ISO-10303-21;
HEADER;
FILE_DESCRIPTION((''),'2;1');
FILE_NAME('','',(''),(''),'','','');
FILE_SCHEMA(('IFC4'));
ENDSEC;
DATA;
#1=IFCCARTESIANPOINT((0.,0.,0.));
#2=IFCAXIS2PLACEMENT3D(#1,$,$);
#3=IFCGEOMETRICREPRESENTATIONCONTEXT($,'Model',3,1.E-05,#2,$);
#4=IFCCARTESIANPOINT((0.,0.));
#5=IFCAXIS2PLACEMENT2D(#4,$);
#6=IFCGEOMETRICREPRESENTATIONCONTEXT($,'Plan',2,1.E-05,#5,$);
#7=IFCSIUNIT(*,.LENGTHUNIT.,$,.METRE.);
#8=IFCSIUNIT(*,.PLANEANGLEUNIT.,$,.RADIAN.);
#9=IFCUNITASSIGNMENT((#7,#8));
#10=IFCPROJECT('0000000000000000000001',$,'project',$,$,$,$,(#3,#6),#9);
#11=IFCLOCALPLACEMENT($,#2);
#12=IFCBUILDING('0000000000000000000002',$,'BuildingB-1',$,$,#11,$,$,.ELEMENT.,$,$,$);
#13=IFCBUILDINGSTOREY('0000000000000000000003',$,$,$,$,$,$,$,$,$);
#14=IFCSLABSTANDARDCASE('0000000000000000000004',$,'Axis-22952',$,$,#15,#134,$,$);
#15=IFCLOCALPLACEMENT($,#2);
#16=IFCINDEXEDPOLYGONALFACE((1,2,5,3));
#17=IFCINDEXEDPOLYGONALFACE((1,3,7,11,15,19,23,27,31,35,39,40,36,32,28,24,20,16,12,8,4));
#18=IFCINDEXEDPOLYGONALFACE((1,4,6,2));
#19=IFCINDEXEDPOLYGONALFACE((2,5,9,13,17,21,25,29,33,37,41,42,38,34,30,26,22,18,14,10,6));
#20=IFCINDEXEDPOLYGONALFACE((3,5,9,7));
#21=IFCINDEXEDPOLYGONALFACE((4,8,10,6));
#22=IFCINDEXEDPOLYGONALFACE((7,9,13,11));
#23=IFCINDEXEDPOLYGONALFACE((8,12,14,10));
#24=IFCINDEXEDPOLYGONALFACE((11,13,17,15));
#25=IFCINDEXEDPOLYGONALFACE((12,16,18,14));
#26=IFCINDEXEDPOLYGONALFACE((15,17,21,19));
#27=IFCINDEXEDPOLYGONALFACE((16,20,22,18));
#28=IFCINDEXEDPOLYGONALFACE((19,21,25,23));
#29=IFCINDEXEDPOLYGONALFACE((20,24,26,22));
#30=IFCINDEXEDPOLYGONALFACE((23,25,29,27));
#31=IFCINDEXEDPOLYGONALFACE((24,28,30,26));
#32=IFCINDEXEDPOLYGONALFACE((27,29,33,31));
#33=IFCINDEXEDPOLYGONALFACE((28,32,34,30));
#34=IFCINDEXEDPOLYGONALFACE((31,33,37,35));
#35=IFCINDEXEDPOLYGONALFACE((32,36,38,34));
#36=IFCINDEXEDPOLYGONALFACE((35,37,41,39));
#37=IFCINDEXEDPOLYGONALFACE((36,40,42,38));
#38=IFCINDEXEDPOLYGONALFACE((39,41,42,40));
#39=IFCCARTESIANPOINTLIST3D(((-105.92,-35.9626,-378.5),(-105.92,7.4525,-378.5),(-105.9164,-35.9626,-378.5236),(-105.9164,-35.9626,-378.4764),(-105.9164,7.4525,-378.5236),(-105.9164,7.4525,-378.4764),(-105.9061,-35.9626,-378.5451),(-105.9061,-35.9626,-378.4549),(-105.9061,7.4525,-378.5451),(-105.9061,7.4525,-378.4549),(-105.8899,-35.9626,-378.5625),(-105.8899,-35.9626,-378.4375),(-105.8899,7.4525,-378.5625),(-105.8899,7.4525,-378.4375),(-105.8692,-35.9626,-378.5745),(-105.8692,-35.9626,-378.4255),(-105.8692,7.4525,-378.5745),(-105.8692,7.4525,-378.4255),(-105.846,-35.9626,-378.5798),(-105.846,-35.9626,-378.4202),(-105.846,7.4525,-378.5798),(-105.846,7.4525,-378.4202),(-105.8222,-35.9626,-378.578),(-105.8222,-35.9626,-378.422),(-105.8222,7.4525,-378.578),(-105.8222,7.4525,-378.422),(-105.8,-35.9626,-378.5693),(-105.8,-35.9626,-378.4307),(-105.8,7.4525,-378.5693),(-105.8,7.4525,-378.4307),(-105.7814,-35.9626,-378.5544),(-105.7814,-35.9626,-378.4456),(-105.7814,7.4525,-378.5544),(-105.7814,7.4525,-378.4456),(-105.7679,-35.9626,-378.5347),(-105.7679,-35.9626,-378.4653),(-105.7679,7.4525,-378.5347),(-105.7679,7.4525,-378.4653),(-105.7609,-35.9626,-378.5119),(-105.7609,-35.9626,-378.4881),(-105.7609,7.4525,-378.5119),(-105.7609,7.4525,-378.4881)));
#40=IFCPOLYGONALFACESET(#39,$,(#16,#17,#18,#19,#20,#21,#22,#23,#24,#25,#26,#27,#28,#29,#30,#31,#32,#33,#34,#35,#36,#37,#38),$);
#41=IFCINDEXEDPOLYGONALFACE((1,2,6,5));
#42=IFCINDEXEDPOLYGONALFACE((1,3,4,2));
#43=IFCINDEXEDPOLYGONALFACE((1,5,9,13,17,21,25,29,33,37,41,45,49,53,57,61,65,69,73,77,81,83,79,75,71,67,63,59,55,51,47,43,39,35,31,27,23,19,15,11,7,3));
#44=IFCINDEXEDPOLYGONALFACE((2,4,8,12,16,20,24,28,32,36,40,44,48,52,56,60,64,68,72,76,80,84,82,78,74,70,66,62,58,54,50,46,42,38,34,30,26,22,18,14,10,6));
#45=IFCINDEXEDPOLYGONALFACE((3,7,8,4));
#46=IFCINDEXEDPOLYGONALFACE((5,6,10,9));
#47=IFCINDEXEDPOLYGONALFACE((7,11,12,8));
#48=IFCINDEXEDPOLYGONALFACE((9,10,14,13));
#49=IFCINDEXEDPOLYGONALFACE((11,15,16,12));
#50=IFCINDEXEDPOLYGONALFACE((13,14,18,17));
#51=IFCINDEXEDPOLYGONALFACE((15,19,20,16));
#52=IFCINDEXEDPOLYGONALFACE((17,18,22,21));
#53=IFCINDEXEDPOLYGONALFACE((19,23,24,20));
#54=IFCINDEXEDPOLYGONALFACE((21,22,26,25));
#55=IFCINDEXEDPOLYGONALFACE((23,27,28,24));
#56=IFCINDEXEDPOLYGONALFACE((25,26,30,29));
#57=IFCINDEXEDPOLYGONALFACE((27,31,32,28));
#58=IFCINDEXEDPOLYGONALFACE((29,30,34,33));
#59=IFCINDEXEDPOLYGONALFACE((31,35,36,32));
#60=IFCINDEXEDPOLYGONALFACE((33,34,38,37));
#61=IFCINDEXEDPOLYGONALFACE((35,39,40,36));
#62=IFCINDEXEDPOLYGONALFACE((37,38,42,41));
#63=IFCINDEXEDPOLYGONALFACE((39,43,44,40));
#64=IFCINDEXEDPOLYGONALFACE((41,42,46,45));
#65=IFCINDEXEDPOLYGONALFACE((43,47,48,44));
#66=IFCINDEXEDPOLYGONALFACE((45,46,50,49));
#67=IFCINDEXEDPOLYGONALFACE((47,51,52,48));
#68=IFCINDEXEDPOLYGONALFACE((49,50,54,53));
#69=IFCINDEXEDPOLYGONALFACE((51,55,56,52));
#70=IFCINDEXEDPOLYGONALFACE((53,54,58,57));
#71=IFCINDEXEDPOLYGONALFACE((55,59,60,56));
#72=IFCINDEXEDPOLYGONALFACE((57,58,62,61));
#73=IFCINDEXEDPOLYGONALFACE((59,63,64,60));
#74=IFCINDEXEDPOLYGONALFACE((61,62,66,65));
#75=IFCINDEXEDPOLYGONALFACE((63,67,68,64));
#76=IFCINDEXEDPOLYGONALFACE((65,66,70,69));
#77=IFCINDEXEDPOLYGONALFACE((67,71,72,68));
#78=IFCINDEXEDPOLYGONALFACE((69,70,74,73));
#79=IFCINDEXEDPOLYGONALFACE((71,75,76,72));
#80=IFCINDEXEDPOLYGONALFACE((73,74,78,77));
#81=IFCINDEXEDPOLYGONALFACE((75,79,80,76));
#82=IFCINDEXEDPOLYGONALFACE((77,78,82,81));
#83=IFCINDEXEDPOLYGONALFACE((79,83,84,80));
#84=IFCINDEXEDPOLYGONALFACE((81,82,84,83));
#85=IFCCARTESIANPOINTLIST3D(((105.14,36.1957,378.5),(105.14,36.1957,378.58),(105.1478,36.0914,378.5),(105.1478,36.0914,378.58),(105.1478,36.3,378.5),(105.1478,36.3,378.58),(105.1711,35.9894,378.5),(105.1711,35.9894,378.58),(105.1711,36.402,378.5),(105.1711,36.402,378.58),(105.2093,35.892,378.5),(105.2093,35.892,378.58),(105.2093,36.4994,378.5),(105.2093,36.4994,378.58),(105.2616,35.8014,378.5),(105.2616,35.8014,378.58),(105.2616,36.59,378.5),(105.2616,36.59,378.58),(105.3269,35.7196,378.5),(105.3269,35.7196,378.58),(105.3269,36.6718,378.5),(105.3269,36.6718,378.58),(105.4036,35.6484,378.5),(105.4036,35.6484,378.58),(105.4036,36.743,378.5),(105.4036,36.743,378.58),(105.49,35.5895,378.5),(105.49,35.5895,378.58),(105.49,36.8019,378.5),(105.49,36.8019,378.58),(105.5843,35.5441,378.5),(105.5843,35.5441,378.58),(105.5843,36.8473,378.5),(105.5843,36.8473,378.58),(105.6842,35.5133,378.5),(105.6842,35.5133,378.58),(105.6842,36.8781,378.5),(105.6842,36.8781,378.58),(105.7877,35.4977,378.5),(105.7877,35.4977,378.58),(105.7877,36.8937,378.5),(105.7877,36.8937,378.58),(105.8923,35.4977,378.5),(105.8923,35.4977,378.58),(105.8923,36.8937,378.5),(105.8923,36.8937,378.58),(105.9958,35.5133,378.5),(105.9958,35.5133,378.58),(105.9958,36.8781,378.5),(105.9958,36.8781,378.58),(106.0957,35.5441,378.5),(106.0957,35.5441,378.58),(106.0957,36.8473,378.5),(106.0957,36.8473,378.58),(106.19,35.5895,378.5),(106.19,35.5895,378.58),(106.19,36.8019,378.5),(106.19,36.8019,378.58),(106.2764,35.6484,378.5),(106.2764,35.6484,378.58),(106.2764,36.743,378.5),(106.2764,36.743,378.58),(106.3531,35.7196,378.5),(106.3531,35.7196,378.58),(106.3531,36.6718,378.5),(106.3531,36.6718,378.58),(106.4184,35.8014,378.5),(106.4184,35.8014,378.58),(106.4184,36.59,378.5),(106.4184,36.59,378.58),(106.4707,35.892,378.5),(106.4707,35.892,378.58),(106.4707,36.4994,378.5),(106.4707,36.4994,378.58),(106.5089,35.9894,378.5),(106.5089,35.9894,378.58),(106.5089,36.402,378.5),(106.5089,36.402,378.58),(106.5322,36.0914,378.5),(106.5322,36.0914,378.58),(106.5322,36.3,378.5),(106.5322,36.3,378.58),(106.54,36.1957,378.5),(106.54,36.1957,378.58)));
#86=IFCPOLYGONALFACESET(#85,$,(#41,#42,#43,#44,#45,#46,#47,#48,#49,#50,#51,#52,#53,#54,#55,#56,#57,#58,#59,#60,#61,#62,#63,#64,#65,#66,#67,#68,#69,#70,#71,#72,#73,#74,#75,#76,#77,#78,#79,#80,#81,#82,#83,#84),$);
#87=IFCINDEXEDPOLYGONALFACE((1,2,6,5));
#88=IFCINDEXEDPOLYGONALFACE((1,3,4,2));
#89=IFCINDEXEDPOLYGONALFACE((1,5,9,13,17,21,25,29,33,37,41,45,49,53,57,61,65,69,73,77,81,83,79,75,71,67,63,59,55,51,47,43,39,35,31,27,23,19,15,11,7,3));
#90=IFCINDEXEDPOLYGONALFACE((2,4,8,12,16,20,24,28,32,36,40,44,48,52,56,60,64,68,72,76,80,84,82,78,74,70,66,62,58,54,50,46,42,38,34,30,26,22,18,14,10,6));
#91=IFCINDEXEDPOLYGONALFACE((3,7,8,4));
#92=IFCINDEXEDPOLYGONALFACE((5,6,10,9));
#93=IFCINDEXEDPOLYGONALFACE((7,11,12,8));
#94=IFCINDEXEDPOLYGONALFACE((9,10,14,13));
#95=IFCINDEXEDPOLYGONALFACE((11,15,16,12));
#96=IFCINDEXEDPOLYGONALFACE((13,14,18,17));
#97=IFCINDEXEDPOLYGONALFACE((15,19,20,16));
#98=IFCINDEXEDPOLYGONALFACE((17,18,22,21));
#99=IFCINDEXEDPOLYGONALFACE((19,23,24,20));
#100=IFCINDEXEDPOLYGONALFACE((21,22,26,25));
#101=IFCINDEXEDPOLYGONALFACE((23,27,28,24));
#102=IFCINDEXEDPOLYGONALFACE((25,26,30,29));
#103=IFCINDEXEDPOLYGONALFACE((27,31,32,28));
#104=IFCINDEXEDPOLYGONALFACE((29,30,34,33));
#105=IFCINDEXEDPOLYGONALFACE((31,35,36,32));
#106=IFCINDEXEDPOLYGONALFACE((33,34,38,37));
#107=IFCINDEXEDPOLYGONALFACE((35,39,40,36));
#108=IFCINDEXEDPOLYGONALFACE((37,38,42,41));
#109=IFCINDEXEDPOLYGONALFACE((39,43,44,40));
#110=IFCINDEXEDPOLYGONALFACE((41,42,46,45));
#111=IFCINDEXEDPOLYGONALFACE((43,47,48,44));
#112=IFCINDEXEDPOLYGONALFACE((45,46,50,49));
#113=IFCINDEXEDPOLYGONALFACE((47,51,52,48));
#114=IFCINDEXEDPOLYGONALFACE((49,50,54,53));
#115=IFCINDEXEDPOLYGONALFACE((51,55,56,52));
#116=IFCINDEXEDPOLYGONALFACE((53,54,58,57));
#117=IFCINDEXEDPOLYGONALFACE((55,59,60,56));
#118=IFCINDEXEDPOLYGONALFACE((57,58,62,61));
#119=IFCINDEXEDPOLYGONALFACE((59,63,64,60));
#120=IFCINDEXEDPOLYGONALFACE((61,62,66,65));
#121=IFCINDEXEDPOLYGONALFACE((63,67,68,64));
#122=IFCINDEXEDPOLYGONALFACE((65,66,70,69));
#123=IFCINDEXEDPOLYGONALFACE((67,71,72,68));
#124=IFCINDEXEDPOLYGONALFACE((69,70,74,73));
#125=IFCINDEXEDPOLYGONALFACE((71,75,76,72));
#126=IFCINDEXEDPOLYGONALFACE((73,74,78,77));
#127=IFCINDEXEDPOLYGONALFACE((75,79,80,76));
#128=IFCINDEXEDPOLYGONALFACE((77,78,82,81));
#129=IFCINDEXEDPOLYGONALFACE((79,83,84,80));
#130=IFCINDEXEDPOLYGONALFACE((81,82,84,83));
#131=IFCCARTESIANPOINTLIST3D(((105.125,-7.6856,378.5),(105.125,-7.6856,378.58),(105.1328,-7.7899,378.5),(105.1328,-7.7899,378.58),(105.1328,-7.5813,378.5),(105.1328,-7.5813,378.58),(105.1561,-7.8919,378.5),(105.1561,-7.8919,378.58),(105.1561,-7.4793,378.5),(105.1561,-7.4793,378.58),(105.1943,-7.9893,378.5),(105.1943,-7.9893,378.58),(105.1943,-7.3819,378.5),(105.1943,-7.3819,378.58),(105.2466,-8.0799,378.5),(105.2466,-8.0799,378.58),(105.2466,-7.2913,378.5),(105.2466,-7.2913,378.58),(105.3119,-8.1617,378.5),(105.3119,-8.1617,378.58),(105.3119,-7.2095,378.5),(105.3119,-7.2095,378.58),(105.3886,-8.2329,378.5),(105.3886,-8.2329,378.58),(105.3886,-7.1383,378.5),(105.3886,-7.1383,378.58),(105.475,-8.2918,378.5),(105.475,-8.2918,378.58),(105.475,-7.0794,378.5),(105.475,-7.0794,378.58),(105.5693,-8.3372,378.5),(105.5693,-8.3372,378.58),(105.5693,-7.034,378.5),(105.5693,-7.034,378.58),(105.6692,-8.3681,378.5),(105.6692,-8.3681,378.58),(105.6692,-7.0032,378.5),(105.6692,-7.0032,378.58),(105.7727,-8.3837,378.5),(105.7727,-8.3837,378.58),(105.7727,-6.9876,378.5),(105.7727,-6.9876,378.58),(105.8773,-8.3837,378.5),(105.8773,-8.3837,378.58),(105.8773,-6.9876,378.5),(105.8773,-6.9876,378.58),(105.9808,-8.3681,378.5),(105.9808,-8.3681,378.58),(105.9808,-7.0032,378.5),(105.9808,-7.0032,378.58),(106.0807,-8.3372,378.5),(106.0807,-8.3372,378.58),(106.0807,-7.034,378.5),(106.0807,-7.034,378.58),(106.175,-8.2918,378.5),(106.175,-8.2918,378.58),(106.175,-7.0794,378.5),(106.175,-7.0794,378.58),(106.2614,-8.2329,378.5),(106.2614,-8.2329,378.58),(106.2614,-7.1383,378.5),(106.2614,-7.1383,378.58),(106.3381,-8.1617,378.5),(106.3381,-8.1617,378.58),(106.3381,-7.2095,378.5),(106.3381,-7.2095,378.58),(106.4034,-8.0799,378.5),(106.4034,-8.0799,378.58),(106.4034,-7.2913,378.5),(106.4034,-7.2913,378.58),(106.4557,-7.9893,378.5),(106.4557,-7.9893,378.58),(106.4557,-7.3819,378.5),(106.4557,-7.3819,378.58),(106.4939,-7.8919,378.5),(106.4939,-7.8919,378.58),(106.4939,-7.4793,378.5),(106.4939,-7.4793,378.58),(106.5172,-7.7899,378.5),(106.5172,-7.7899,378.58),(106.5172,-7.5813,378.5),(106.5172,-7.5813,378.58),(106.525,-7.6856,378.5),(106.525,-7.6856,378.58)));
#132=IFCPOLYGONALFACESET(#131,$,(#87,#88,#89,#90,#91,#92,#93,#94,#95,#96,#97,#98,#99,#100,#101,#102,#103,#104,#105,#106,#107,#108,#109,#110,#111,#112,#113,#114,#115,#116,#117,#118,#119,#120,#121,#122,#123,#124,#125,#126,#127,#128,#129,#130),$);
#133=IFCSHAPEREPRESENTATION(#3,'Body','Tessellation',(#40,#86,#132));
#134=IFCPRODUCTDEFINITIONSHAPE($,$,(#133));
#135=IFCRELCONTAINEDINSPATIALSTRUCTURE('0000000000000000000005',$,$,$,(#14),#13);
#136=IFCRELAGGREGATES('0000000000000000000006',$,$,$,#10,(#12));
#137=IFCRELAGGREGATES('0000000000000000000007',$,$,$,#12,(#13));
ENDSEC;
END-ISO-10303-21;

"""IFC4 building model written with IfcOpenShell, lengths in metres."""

from ifc_helpers import new_model, entity, si_unit, frame, origin, origin_2d, place, context, project, spatial, circle, extrude, element, save


model = new_model("IFC4")

# Units and contexts
model_context = context("Model", 3, precision=1e-05, world=origin())
plan_context = context("Plan", 2, precision=1e-05, world=origin_2d())
ifc_project = project(units=[si_unit("LENGTHUNIT", "METRE"), si_unit("PLANEANGLEUNIT", "RADIAN")], contexts=[model_context, plan_context])

# Building, storey
building_placement = place(None, origin())
building = spatial("IfcBuilding", under=ifc_project, at=building_placement, Name="BuildingB-1", CompositionType="ELEMENT")
storey = spatial("IfcBuildingStorey", under=building)

# Slab
element("IfcSlabStandardCase", 1, inside=storey, Name="Axis-22952", context=model_context, shape_type="AdvancedSweptSolid", body=[
    entity("IfcSurfaceCurveSweptAreaSolid", entity("IfcCircleProfileDef", "AREA", None, None, 0.08), None, entity("IfcPolyline", [entity("IfcCartesianPoint", [105.84, 35.9626, 378.5]), entity("IfcCartesianPoint", [105.84, -7.4525, 378.5])]), None, None, entity("IfcPlane", entity("IfcAxis2Placement3D", entity("IfcCartesianPoint", [105.84, 35.9626, 378.5]), entity("IfcDirection", [0.0, 0.0, 1.0]), entity("IfcDirection", [1.0, 0.0, 0.0])))),
    extrude(circle(Radius=0.7), frame((105.84, 36.1957, 378.5)), (0.0, 0.0, 1.0), 0.08),
    extrude(circle(Radius=0.7), frame((105.825, -7.6856, 378.5)), (0.0, 0.0, 1.0), 0.08),
])

save(model, "model.ifc")
